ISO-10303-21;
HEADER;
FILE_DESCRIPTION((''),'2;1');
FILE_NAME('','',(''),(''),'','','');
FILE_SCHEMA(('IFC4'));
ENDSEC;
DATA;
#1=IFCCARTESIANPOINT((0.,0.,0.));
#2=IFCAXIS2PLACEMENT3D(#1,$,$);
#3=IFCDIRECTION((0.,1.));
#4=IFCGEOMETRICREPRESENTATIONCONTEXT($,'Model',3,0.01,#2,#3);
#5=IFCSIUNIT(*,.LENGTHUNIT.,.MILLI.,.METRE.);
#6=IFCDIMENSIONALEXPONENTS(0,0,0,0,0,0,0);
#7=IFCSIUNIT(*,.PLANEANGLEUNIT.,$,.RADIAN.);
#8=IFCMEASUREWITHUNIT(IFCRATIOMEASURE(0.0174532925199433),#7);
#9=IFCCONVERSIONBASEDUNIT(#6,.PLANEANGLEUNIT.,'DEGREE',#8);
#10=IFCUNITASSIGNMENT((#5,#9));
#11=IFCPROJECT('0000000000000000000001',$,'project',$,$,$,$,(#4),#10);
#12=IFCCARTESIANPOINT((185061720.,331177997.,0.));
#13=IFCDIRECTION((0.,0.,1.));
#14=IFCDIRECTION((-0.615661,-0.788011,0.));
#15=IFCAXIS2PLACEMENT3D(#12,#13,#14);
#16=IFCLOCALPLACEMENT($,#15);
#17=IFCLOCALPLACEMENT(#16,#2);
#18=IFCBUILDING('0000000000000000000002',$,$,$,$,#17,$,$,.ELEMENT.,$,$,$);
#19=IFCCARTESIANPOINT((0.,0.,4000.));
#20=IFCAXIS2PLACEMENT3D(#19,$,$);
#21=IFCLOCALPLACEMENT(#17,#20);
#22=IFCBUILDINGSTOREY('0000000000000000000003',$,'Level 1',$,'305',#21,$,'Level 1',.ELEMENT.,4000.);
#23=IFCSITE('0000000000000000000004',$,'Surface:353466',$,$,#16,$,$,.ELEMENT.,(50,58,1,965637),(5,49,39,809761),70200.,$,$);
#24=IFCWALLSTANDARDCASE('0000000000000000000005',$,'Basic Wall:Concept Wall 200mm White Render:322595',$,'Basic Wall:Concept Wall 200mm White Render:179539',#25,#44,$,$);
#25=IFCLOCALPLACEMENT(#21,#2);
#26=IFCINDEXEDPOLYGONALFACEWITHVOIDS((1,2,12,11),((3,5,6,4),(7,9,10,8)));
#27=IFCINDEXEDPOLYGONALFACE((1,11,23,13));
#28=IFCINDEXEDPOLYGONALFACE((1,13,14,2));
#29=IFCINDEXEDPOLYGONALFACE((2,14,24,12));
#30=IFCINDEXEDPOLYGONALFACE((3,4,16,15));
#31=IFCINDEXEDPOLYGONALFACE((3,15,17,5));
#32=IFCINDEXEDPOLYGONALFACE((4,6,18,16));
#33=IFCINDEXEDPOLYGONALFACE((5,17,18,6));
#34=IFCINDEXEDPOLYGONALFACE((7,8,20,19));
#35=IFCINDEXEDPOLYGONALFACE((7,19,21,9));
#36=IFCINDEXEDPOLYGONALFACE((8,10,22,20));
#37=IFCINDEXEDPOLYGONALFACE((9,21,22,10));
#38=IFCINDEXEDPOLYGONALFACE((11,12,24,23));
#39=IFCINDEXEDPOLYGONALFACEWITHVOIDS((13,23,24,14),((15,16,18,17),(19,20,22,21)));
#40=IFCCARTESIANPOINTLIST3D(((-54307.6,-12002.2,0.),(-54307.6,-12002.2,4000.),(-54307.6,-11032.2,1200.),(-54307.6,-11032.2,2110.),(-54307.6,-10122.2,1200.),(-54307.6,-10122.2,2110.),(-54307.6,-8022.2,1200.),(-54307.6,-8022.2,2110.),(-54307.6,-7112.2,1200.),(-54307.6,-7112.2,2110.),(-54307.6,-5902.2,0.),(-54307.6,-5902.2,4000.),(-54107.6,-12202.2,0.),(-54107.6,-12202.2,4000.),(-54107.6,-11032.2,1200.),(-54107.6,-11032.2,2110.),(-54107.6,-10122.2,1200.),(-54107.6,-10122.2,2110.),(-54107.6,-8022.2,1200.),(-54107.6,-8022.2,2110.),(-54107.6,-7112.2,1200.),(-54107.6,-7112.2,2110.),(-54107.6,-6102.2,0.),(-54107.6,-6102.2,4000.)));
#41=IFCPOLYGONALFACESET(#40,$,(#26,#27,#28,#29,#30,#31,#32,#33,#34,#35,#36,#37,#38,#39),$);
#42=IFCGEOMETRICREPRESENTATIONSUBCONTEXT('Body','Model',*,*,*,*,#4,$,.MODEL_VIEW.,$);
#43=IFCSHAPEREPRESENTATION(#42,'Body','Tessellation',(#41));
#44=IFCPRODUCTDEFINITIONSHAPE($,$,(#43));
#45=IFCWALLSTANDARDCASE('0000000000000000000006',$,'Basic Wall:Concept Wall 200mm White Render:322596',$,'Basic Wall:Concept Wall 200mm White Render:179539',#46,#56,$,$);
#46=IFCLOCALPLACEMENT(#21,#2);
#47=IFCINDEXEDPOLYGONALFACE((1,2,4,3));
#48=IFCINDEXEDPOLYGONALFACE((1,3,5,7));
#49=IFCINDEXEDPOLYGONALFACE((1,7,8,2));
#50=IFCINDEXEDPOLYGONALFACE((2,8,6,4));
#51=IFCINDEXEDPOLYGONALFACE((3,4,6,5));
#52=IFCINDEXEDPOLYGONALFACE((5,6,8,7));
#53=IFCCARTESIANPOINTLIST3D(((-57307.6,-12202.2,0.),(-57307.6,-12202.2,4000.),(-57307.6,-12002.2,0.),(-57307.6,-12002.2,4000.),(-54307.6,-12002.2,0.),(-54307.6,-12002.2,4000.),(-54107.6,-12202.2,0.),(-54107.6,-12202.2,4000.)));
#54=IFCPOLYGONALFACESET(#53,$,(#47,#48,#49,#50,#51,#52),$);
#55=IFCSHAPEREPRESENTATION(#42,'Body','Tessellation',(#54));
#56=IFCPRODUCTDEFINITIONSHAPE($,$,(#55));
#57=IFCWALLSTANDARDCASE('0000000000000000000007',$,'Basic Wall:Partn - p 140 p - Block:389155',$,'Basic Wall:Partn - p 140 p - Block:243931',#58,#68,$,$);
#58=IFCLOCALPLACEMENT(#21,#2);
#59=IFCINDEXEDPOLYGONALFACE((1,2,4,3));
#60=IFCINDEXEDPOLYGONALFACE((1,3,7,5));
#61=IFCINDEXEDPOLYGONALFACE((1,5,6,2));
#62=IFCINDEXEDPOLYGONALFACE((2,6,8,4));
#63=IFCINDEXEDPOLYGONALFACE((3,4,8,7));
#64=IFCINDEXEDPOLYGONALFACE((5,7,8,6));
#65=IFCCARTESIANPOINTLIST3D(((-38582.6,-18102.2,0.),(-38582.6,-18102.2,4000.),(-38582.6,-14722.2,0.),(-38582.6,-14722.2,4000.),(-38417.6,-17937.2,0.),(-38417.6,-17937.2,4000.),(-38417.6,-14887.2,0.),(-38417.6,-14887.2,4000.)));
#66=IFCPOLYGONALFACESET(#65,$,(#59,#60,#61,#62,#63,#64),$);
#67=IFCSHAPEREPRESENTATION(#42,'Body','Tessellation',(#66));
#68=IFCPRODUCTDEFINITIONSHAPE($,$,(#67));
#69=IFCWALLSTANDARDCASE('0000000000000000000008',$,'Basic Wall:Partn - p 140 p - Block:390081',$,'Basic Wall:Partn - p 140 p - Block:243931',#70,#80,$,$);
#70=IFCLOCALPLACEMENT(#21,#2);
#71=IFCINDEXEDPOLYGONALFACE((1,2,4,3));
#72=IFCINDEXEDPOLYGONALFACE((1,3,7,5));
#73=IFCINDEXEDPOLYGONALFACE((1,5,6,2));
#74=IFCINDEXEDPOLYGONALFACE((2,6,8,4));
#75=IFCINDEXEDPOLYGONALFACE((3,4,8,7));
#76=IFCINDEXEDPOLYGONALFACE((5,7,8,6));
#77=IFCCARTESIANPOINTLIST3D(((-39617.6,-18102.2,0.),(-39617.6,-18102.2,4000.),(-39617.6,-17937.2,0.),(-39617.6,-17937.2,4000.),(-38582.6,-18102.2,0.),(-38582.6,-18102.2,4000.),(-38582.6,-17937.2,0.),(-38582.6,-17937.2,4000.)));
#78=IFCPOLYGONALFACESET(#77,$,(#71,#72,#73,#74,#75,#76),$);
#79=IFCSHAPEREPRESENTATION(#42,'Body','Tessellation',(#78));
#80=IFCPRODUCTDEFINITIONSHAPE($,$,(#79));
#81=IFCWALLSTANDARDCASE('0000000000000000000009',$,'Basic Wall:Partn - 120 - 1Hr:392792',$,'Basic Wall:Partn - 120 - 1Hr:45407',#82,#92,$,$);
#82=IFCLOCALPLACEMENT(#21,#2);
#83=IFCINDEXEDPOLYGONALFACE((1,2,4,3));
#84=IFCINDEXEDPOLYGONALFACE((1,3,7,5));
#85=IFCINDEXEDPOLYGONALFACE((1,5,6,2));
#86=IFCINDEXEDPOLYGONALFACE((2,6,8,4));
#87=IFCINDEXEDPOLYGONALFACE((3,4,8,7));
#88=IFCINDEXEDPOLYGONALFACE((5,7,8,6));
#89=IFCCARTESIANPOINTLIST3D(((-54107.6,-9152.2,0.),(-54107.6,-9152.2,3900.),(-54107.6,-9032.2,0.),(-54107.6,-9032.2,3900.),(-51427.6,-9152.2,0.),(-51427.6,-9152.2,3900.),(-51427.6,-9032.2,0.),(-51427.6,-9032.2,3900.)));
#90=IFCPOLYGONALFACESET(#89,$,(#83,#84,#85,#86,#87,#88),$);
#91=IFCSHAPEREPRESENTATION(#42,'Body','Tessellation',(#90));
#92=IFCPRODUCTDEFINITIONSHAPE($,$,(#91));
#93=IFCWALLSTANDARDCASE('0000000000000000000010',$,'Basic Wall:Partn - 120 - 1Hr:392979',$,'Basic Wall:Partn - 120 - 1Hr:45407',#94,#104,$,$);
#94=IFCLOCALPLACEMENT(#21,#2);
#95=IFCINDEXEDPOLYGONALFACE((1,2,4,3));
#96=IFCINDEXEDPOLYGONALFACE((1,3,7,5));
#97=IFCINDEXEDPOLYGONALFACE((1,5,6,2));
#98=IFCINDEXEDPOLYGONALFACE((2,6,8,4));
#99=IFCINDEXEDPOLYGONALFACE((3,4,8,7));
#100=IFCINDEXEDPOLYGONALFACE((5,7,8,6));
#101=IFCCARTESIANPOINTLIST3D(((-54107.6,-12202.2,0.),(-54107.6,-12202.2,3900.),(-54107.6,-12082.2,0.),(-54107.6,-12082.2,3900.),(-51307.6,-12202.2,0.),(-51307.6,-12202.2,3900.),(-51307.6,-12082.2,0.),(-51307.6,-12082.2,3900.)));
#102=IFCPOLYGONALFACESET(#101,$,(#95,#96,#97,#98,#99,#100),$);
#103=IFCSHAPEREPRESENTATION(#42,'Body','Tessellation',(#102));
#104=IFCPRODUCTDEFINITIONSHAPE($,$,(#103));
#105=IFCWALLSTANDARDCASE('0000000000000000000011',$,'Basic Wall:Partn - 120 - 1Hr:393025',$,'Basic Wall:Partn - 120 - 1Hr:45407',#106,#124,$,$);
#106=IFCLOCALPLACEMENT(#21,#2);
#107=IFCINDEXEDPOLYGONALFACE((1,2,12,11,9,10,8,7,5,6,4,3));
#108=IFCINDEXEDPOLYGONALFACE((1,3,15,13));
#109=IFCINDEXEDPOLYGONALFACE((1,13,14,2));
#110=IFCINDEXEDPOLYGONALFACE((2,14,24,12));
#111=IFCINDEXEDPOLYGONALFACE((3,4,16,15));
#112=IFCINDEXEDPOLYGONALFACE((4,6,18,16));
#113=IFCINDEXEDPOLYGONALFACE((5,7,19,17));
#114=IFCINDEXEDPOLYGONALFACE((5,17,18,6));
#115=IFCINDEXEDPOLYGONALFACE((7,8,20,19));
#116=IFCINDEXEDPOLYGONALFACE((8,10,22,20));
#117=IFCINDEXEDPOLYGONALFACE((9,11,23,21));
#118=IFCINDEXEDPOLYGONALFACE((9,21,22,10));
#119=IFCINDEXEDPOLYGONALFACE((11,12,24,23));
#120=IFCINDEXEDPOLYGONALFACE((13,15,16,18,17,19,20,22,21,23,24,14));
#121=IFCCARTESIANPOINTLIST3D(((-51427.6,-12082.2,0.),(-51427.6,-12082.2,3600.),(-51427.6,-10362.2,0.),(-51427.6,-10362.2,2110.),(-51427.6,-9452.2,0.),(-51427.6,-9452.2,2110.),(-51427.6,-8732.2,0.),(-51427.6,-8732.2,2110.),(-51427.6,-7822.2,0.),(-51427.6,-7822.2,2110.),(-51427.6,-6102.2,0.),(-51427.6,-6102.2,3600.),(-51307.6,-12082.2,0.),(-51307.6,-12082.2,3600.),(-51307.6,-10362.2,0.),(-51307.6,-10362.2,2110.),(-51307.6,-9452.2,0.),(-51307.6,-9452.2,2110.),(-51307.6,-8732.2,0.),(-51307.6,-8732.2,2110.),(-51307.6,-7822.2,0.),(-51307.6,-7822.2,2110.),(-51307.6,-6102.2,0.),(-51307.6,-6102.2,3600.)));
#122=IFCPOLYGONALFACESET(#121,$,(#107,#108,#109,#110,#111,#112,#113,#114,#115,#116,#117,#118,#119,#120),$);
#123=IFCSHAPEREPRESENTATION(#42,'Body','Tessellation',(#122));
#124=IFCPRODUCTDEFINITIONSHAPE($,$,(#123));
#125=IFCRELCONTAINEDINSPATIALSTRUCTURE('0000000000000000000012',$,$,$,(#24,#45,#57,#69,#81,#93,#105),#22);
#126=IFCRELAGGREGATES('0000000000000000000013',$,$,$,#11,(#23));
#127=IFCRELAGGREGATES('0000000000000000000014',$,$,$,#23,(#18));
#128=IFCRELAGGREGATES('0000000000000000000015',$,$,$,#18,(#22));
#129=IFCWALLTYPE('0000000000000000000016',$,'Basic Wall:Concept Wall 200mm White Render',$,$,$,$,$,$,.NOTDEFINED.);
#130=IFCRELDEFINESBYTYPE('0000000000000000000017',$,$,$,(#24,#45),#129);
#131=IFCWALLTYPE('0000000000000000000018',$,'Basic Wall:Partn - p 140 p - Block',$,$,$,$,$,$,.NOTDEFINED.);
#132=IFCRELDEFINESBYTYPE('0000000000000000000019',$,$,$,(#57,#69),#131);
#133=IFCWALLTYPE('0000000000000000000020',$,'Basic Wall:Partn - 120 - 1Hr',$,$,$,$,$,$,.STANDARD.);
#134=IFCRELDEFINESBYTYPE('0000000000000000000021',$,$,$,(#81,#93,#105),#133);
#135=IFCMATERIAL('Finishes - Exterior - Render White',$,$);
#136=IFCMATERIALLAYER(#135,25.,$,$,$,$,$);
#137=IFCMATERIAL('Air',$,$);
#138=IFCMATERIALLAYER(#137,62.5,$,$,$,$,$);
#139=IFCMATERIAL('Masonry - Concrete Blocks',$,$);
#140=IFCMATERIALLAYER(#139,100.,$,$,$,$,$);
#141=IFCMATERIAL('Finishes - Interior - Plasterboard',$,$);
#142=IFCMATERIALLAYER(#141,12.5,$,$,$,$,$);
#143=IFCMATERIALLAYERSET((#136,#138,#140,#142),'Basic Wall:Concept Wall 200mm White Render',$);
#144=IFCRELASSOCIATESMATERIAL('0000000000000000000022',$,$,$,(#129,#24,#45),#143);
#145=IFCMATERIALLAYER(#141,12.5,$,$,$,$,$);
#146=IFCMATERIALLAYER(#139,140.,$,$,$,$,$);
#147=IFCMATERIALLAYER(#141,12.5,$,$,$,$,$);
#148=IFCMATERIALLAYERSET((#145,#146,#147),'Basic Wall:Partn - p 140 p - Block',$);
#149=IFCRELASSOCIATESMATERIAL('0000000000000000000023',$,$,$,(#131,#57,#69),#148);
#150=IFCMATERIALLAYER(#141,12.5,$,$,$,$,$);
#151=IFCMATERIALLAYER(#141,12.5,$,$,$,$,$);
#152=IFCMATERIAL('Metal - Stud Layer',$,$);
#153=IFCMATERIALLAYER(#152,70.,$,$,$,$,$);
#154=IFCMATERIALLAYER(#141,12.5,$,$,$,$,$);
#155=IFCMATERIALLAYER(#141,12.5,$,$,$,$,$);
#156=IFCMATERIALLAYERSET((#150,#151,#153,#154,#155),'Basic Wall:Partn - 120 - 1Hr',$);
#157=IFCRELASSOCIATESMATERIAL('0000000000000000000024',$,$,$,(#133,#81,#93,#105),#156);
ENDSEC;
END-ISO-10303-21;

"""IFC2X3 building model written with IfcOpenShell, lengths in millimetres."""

from ifc_helpers import new_model, entity, si_unit, converted_unit, direction, frame, frame_2d, origin, place, context, subcontext, project, spatial, polyline, rectangle, outline, extrude, clip, halfspace, bounded_halfspace, material, layer, layer_set, layer_usage, type_object, element, save


model = new_model("IFC2X3")

# Units and contexts
model_context = context("Model", 3, precision=0.01, world=origin(), true_north=direction((0.0, 1.0)))
body_context = subcontext(model_context, "Body", "Model", "MODEL_VIEW")
ifc_project = project(units=[si_unit("LENGTHUNIT", "METRE", prefix="MILLI"), converted_unit("PLANEANGLEUNIT", "DEGREE", entity("IfcRatioMeasure", 0.0174532925199433), si_unit("PLANEANGLEUNIT", "RADIAN"), dimensions=[0, 0, 0, 0, 0, 0, 0])], contexts=[model_context])

# Site, building, storey
site_placement = place(None, frame((185061720.0, 331177997.0, 0.0), z_axis=(0.0, 0.0, 1.0), x_axis=(-0.615661, -0.788011, 0.0)))
site = spatial("IfcSite", under=ifc_project, at=site_placement, Name="Surface:353466", CompositionType="ELEMENT", RefLatitude=(50, 58, 1, 965637), RefLongitude=(5, 49, 39, 809761), RefElevation=70200.0)
building_placement = place(site_placement, origin())
building = spatial("IfcBuilding", under=site, at=building_placement, CompositionType="ELEMENT")
storey_placement = place(building_placement, frame((0.0, 0.0, 4000.0)))
storey = spatial("IfcBuildingStorey", under=building, at=storey_placement, Name="Level 1", ObjectType="305", LongName="Level 1", CompositionType="ELEMENT", Elevation=4000.0)

# Shared definitions
ifc_material_1 = material(Name="Masonry - Concrete Blocks")
ifc_material_2 = material(Name="Finishes - Interior - Plasterboard")

# Wall, openings
ifc_material_3 = material(Name="Finishes - Exterior - Render White")
ifc_layer_1 = layer(ifc_material_3, 25.0)
ifc_material_4 = material(Name="Air")
ifc_layer_2 = layer(ifc_material_4, 62.5)
ifc_layer_3 = layer(ifc_material_1, 100.0)
ifc_layer_4 = layer(ifc_material_2, 12.5)
ifc_layer_set_1 = layer_set([ifc_layer_1, ifc_layer_2, ifc_layer_3, ifc_layer_4], Name="Basic Wall:Concept Wall 200mm White Render")
ifc_layer_usage_1 = layer_usage(ifc_layer_set_1, "AXIS2", "POSITIVE", -100.0)
wall_type_1 = type_object("IfcWallType", Name="Basic Wall:Concept Wall 200mm White Render", PredefinedType="NOTDEFINED", material=ifc_layer_set_1)
wall_1_placement = place(storey_placement, frame((-54207.6, -5902.2, 0.0), z_axis=(0.0, 0.0, 1.0), x_axis=(0.0, -1.0, 0.0)))
wall_1 = element("IfcWallStandardCase", 1, at=wall_1_placement, inside=storey, type_object=wall_type_1, material=ifc_layer_usage_1, Name="Basic Wall:Concept Wall 200mm White Render:322595", ObjectType="Basic Wall:Concept Wall 200mm White Render:179539", context=body_context, shape_type="Clipping", body=[
    clip(extrude(outline(polyline([(6100.0, -100.0), (6300.0, 100.0), (6135.0, 100.0), (200.0, 100.0), (0.0, -100.0), (6100.0, -100.0)])), origin(), (0.0, 0.0, 1.0), 4000.0), halfspace(frame((0.0, 0.0, -4000.0)), True)),
])
opening_1_placement = place(wall_1_placement, frame((2120.0, -1424.0, 1200.0)))
element("IfcOpeningElement", 2, at=opening_1_placement, cuts=wall_1, ObjectType="Opening", context=body_context, shape_type="SweptSolid", body=[
    extrude(rectangle(XDim=910.0, YDim=910.0, at=frame_2d((0.0, 0.0), x_axis=(1.0, 0.0))), frame((-455.0, 0.0, 455.0), z_axis=(0.0, 1.0, 0.0), x_axis=(0.0, 0.0, -1.0)), (0.0, 0.0, 1.0), 3048.0),
])
opening_2_placement = place(wall_1_placement, frame((5130.0, -1424.0, 1200.0)))
element("IfcOpeningElement", 3, at=opening_2_placement, cuts=wall_1, ObjectType="Opening", context=body_context, shape_type="SweptSolid", body=[
    extrude(rectangle(XDim=910.0, YDim=910.0, at=frame_2d((0.0, 0.0), x_axis=(1.0, 0.0))), frame((-455.0, 0.0, 455.0), z_axis=(0.0, 1.0, 0.0), x_axis=(0.0, 0.0, -1.0)), (0.0, 0.0, 1.0), 3048.0),
])
opening_3_placement = place(wall_1_placement, frame((2120.0, 100.0, 1200.0)))
element("IfcOpeningElement", 4, at=opening_3_placement, cuts=wall_1, ObjectType="Opening", context=body_context, shape_type="SweptSolid", body=[
    extrude(rectangle(XDim=910.0, YDim=910.0, at=frame_2d((455.0, 455.0), x_axis=(-1.0, 0.0))), frame((0.0, 0.0, 0.0), z_axis=(0.0, -1.0, 0.0), x_axis=(0.0, 0.0, 1.0)), (0.0, 0.0, 1.0), 200.0),
])
opening_4_placement = place(wall_1_placement, frame((5130.0, 100.0, 1200.0)))
element("IfcOpeningElement", 5, at=opening_4_placement, cuts=wall_1, ObjectType="Opening", context=body_context, shape_type="SweptSolid", body=[
    extrude(rectangle(XDim=910.0, YDim=910.0, at=frame_2d((455.0, 455.0), x_axis=(-1.0, 0.0))), frame((0.0, 0.0, 0.0), z_axis=(0.0, -1.0, 0.0), x_axis=(0.0, 0.0, 1.0)), (0.0, 0.0, 1.0), 200.0),
])

# Walls
ifc_layer_usage_2 = layer_usage(ifc_layer_set_1, "AXIS2", "POSITIVE", -100.0)
wall_2_placement = place(storey_placement, frame((-54107.6, -12102.2, 0.0), z_axis=(0.0, 0.0, 1.0), x_axis=(-1.0, 0.0, 0.0)))
element("IfcWallStandardCase", 6, at=wall_2_placement, inside=storey, type_object=wall_type_1, material=ifc_layer_usage_2, Name="Basic Wall:Concept Wall 200mm White Render:322596", ObjectType="Basic Wall:Concept Wall 200mm White Render:179539", context=body_context, shape_type="Clipping", body=[
    clip(extrude(outline(polyline([(200.0, -100.0), (3200.0, -100.0), (3200.0, 100.0), (0.0, 100.0), (200.0, -100.0)])), origin(), (0.0, 0.0, 1.0), 4000.0), halfspace(frame((0.0, 0.0, -4000.0)), True)),
])
ifc_layer_5 = layer(ifc_material_2, 12.5)
ifc_layer_6 = layer(ifc_material_1, 140.0)
ifc_layer_7 = layer(ifc_material_2, 12.5)
ifc_layer_set_2 = layer_set([ifc_layer_5, ifc_layer_6, ifc_layer_7], Name="Basic Wall:Partn - p 140 p - Block")
ifc_layer_usage_3 = layer_usage(ifc_layer_set_2, "AXIS2", "NEGATIVE", 82.5)
wall_type_2 = type_object("IfcWallType", Name="Basic Wall:Partn - p 140 p - Block", PredefinedType="NOTDEFINED", material=ifc_layer_set_2)
wall_3_placement = place(storey_placement, frame((-38500.1, -18102.2, 0.0), z_axis=(0.0, 0.0, 1.0), x_axis=(0.0, 1.0, 0.0)))
element("IfcWallStandardCase", 7, at=wall_3_placement, inside=storey, type_object=wall_type_2, material=ifc_layer_usage_3, Name="Basic Wall:Partn - p 140 p - Block:389155", ObjectType="Basic Wall:Partn - p 140 p - Block:243931", context=body_context, shape_type="Clipping", body=[
    clip(extrude(outline(polyline([(3215.0, -82.5), (3380.0, 82.5), (0.0, 82.5), (165.0, -82.5), (3215.0, -82.5)])), origin(), (0.0, 0.0, 1.0), 4000.0), halfspace(frame((0.0, 0.0, -4000.0)), True)),
])
ifc_layer_usage_4 = layer_usage(ifc_layer_set_2, "AXIS2", "POSITIVE", -82.5)
wall_4_placement = place(storey_placement, frame((-39617.6, -18019.7, 0.0)))
element("IfcWallStandardCase", 8, at=wall_4_placement, inside=storey, type_object=wall_type_2, material=ifc_layer_usage_4, Name="Basic Wall:Partn - p 140 p - Block:390081", ObjectType="Basic Wall:Partn - p 140 p - Block:243931", context=body_context, shape_type="Clipping", body=[
    clip(extrude(rectangle(XDim=1035.0, YDim=165.0, at=frame_2d((517.5, 0.0), x_axis=(-1.0, 0.0))), origin(), (0.0, 0.0, 1.0), 4000.0), halfspace(origin(), True)),
])

# Walls
ifc_layer_8 = layer(ifc_material_2, 12.5)
ifc_layer_9 = layer(ifc_material_2, 12.5)
ifc_material_5 = material(Name="Metal - Stud Layer")
ifc_layer_10 = layer(ifc_material_5, 70.0)
ifc_layer_11 = layer(ifc_material_2, 12.5)
ifc_layer_12 = layer(ifc_material_2, 12.5)
ifc_layer_set_3 = layer_set([ifc_layer_8, ifc_layer_9, ifc_layer_10, ifc_layer_11, ifc_layer_12], Name="Basic Wall:Partn - 120 - 1Hr")
ifc_layer_usage_5 = layer_usage(ifc_layer_set_3, "AXIS2", "NEGATIVE", 60.0)
wall_type_3 = type_object("IfcWallType", Name="Basic Wall:Partn - 120 - 1Hr", PredefinedType="STANDARD", material=ifc_layer_set_3)
wall_5_placement = place(storey_placement, frame((-54107.6, -9092.2, 0.0)))
element("IfcWallStandardCase", 9, at=wall_5_placement, inside=storey, type_object=wall_type_3, material=ifc_layer_usage_5, Name="Basic Wall:Partn - 120 - 1Hr:392792", ObjectType="Basic Wall:Partn - 120 - 1Hr:45407", context=body_context, shape_type="Clipping", body=[
    clip(extrude(rectangle(XDim=2680.0, YDim=120.0, at=frame_2d((1340.0, 0.0), x_axis=(-1.0, 0.0))), origin(), (0.0, 0.0, 1.0), 3900.0), bounded_halfspace(frame((0.0, -60.0, 3900.0), z_axis=(0.0, 0.0, -1.0), x_axis=(0.0, -1.0, 0.0)), True, frame((0.0, -60.0, 3900.0)), polyline([(0.0, 0.0), (2680.0, 0.0), (2680.0, 120.0), (0.0, 120.0), (0.0, 0.0)]))),
])
ifc_layer_usage_6 = layer_usage(ifc_layer_set_3, "AXIS2", "POSITIVE", -60.0)
wall_6_placement = place(storey_placement, frame((-54107.6, -12142.2, 0.0)))
element("IfcWallStandardCase", 10, at=wall_6_placement, inside=storey, type_object=wall_type_3, material=ifc_layer_usage_6, Name="Basic Wall:Partn - 120 - 1Hr:392979", ObjectType="Basic Wall:Partn - 120 - 1Hr:45407", context=body_context, shape_type="Clipping", body=[
    clip(extrude(rectangle(XDim=2800.0, YDim=120.0, at=frame_2d((1400.0, 0.0), x_axis=(-1.0, 0.0))), origin(), (0.0, 0.0, 1.0), 3900.0), bounded_halfspace(frame((0.0, -60.0, 3900.0), z_axis=(0.0, 0.0, -1.0), x_axis=(0.0, -1.0, 0.0)), True, frame((0.0, -60.0, 3900.0)), polyline([(0.0, 0.0), (2800.0, 0.0), (2800.0, 12.5), (2800.0, 120.0), (0.0, 120.0), (0.0, 12.5), (0.0, 0.0)]))),
])

# Wall, openings
ifc_layer_usage_7 = layer_usage(ifc_layer_set_3, "AXIS2", "POSITIVE", -60.0)
wall_7_placement = place(storey_placement, frame((-51367.6, -12082.2, 0.0), z_axis=(0.0, 0.0, 1.0), x_axis=(0.0, 1.0, 0.0)))
wall_7 = element("IfcWallStandardCase", 11, at=wall_7_placement, inside=storey, type_object=wall_type_3, material=ifc_layer_usage_7, Name="Basic Wall:Partn - 120 - 1Hr:393025", ObjectType="Basic Wall:Partn - 120 - 1Hr:45407", context=body_context, shape_type="Clipping", body=[
    clip(extrude(rectangle(XDim=5980.0, YDim=120.0, at=frame_2d((2990.0, 0.0), x_axis=(-1.0, 0.0))), origin(), (0.0, 0.0, 1.0), 3600.0), bounded_halfspace(frame((0.0, -60.0, 3600.0), z_axis=(0.0, 0.0, -1.0), x_axis=(0.0, -1.0, 0.0)), True, frame((0.0, -60.0, 3600.0)), polyline([(0.0, 0.0), (5980.0, 0.0), (5980.0, 120.0), (0.0, 120.0), (0.0, 0.0)]))),
])
opening_5_placement = place(wall_7_placement, frame((3350.0, 1464.0, 0.0)))
element("IfcOpeningElement", 12, at=opening_5_placement, cuts=wall_7, ObjectType="Opening", context=body_context, shape_type="SweptSolid", body=[
    extrude(rectangle(XDim=2110.0, YDim=910.0, at=frame_2d((0.0, 0.0), x_axis=(1.0, 0.0))), frame((455.0, -3048.0, 1055.0), z_axis=(0.0, 1.0, 0.0), x_axis=(0.0, 0.0, 1.0)), (0.0, 0.0, 1.0), 3048.0),
])
opening_6_placement = place(wall_7_placement, frame((1720.0, 1464.0, 0.0)))
element("IfcOpeningElement", 13, at=opening_6_placement, cuts=wall_7, ObjectType="Opening", context=body_context, shape_type="SweptSolid", body=[
    extrude(rectangle(XDim=2110.0, YDim=910.0, at=frame_2d((0.0, 0.0), x_axis=(0.0, 1.0))), frame((455.0, -3048.0, 1055.0), z_axis=(0.0, 1.0, 0.0), x_axis=(-1.0, 0.0, 0.0)), (0.0, 0.0, 1.0), 3048.0),
])
opening_7_placement = place(wall_7_placement, frame((3350.0, -60.0, 0.0)))
element("IfcOpeningElement", 14, at=opening_7_placement, cuts=wall_7, ObjectType="Opening", context=body_context, shape_type="SweptSolid", body=[
    extrude(rectangle(XDim=2110.0, YDim=910.0, at=frame_2d((1055.0, 455.0), x_axis=(1.0, 0.0))), frame((0.0, 0.0, 0.0), z_axis=(0.0, 1.0, 0.0), x_axis=(0.0, 0.0, 1.0)), (0.0, 0.0, 1.0), 120.0),
])
opening_8_placement = place(wall_7_placement, frame((1720.0, -60.0, 0.0)))
element("IfcOpeningElement", 15, at=opening_8_placement, cuts=wall_7, ObjectType="Opening", context=body_context, shape_type="SweptSolid", body=[
    extrude(rectangle(XDim=2110.0, YDim=910.0, at=frame_2d((1055.0, 455.0), x_axis=(1.0, 0.0))), frame((0.0, 0.0, 0.0), z_axis=(0.0, 1.0, 0.0), x_axis=(0.0, 0.0, 1.0)), (0.0, 0.0, 1.0), 120.0),
])

save(model, "model.ifc")
